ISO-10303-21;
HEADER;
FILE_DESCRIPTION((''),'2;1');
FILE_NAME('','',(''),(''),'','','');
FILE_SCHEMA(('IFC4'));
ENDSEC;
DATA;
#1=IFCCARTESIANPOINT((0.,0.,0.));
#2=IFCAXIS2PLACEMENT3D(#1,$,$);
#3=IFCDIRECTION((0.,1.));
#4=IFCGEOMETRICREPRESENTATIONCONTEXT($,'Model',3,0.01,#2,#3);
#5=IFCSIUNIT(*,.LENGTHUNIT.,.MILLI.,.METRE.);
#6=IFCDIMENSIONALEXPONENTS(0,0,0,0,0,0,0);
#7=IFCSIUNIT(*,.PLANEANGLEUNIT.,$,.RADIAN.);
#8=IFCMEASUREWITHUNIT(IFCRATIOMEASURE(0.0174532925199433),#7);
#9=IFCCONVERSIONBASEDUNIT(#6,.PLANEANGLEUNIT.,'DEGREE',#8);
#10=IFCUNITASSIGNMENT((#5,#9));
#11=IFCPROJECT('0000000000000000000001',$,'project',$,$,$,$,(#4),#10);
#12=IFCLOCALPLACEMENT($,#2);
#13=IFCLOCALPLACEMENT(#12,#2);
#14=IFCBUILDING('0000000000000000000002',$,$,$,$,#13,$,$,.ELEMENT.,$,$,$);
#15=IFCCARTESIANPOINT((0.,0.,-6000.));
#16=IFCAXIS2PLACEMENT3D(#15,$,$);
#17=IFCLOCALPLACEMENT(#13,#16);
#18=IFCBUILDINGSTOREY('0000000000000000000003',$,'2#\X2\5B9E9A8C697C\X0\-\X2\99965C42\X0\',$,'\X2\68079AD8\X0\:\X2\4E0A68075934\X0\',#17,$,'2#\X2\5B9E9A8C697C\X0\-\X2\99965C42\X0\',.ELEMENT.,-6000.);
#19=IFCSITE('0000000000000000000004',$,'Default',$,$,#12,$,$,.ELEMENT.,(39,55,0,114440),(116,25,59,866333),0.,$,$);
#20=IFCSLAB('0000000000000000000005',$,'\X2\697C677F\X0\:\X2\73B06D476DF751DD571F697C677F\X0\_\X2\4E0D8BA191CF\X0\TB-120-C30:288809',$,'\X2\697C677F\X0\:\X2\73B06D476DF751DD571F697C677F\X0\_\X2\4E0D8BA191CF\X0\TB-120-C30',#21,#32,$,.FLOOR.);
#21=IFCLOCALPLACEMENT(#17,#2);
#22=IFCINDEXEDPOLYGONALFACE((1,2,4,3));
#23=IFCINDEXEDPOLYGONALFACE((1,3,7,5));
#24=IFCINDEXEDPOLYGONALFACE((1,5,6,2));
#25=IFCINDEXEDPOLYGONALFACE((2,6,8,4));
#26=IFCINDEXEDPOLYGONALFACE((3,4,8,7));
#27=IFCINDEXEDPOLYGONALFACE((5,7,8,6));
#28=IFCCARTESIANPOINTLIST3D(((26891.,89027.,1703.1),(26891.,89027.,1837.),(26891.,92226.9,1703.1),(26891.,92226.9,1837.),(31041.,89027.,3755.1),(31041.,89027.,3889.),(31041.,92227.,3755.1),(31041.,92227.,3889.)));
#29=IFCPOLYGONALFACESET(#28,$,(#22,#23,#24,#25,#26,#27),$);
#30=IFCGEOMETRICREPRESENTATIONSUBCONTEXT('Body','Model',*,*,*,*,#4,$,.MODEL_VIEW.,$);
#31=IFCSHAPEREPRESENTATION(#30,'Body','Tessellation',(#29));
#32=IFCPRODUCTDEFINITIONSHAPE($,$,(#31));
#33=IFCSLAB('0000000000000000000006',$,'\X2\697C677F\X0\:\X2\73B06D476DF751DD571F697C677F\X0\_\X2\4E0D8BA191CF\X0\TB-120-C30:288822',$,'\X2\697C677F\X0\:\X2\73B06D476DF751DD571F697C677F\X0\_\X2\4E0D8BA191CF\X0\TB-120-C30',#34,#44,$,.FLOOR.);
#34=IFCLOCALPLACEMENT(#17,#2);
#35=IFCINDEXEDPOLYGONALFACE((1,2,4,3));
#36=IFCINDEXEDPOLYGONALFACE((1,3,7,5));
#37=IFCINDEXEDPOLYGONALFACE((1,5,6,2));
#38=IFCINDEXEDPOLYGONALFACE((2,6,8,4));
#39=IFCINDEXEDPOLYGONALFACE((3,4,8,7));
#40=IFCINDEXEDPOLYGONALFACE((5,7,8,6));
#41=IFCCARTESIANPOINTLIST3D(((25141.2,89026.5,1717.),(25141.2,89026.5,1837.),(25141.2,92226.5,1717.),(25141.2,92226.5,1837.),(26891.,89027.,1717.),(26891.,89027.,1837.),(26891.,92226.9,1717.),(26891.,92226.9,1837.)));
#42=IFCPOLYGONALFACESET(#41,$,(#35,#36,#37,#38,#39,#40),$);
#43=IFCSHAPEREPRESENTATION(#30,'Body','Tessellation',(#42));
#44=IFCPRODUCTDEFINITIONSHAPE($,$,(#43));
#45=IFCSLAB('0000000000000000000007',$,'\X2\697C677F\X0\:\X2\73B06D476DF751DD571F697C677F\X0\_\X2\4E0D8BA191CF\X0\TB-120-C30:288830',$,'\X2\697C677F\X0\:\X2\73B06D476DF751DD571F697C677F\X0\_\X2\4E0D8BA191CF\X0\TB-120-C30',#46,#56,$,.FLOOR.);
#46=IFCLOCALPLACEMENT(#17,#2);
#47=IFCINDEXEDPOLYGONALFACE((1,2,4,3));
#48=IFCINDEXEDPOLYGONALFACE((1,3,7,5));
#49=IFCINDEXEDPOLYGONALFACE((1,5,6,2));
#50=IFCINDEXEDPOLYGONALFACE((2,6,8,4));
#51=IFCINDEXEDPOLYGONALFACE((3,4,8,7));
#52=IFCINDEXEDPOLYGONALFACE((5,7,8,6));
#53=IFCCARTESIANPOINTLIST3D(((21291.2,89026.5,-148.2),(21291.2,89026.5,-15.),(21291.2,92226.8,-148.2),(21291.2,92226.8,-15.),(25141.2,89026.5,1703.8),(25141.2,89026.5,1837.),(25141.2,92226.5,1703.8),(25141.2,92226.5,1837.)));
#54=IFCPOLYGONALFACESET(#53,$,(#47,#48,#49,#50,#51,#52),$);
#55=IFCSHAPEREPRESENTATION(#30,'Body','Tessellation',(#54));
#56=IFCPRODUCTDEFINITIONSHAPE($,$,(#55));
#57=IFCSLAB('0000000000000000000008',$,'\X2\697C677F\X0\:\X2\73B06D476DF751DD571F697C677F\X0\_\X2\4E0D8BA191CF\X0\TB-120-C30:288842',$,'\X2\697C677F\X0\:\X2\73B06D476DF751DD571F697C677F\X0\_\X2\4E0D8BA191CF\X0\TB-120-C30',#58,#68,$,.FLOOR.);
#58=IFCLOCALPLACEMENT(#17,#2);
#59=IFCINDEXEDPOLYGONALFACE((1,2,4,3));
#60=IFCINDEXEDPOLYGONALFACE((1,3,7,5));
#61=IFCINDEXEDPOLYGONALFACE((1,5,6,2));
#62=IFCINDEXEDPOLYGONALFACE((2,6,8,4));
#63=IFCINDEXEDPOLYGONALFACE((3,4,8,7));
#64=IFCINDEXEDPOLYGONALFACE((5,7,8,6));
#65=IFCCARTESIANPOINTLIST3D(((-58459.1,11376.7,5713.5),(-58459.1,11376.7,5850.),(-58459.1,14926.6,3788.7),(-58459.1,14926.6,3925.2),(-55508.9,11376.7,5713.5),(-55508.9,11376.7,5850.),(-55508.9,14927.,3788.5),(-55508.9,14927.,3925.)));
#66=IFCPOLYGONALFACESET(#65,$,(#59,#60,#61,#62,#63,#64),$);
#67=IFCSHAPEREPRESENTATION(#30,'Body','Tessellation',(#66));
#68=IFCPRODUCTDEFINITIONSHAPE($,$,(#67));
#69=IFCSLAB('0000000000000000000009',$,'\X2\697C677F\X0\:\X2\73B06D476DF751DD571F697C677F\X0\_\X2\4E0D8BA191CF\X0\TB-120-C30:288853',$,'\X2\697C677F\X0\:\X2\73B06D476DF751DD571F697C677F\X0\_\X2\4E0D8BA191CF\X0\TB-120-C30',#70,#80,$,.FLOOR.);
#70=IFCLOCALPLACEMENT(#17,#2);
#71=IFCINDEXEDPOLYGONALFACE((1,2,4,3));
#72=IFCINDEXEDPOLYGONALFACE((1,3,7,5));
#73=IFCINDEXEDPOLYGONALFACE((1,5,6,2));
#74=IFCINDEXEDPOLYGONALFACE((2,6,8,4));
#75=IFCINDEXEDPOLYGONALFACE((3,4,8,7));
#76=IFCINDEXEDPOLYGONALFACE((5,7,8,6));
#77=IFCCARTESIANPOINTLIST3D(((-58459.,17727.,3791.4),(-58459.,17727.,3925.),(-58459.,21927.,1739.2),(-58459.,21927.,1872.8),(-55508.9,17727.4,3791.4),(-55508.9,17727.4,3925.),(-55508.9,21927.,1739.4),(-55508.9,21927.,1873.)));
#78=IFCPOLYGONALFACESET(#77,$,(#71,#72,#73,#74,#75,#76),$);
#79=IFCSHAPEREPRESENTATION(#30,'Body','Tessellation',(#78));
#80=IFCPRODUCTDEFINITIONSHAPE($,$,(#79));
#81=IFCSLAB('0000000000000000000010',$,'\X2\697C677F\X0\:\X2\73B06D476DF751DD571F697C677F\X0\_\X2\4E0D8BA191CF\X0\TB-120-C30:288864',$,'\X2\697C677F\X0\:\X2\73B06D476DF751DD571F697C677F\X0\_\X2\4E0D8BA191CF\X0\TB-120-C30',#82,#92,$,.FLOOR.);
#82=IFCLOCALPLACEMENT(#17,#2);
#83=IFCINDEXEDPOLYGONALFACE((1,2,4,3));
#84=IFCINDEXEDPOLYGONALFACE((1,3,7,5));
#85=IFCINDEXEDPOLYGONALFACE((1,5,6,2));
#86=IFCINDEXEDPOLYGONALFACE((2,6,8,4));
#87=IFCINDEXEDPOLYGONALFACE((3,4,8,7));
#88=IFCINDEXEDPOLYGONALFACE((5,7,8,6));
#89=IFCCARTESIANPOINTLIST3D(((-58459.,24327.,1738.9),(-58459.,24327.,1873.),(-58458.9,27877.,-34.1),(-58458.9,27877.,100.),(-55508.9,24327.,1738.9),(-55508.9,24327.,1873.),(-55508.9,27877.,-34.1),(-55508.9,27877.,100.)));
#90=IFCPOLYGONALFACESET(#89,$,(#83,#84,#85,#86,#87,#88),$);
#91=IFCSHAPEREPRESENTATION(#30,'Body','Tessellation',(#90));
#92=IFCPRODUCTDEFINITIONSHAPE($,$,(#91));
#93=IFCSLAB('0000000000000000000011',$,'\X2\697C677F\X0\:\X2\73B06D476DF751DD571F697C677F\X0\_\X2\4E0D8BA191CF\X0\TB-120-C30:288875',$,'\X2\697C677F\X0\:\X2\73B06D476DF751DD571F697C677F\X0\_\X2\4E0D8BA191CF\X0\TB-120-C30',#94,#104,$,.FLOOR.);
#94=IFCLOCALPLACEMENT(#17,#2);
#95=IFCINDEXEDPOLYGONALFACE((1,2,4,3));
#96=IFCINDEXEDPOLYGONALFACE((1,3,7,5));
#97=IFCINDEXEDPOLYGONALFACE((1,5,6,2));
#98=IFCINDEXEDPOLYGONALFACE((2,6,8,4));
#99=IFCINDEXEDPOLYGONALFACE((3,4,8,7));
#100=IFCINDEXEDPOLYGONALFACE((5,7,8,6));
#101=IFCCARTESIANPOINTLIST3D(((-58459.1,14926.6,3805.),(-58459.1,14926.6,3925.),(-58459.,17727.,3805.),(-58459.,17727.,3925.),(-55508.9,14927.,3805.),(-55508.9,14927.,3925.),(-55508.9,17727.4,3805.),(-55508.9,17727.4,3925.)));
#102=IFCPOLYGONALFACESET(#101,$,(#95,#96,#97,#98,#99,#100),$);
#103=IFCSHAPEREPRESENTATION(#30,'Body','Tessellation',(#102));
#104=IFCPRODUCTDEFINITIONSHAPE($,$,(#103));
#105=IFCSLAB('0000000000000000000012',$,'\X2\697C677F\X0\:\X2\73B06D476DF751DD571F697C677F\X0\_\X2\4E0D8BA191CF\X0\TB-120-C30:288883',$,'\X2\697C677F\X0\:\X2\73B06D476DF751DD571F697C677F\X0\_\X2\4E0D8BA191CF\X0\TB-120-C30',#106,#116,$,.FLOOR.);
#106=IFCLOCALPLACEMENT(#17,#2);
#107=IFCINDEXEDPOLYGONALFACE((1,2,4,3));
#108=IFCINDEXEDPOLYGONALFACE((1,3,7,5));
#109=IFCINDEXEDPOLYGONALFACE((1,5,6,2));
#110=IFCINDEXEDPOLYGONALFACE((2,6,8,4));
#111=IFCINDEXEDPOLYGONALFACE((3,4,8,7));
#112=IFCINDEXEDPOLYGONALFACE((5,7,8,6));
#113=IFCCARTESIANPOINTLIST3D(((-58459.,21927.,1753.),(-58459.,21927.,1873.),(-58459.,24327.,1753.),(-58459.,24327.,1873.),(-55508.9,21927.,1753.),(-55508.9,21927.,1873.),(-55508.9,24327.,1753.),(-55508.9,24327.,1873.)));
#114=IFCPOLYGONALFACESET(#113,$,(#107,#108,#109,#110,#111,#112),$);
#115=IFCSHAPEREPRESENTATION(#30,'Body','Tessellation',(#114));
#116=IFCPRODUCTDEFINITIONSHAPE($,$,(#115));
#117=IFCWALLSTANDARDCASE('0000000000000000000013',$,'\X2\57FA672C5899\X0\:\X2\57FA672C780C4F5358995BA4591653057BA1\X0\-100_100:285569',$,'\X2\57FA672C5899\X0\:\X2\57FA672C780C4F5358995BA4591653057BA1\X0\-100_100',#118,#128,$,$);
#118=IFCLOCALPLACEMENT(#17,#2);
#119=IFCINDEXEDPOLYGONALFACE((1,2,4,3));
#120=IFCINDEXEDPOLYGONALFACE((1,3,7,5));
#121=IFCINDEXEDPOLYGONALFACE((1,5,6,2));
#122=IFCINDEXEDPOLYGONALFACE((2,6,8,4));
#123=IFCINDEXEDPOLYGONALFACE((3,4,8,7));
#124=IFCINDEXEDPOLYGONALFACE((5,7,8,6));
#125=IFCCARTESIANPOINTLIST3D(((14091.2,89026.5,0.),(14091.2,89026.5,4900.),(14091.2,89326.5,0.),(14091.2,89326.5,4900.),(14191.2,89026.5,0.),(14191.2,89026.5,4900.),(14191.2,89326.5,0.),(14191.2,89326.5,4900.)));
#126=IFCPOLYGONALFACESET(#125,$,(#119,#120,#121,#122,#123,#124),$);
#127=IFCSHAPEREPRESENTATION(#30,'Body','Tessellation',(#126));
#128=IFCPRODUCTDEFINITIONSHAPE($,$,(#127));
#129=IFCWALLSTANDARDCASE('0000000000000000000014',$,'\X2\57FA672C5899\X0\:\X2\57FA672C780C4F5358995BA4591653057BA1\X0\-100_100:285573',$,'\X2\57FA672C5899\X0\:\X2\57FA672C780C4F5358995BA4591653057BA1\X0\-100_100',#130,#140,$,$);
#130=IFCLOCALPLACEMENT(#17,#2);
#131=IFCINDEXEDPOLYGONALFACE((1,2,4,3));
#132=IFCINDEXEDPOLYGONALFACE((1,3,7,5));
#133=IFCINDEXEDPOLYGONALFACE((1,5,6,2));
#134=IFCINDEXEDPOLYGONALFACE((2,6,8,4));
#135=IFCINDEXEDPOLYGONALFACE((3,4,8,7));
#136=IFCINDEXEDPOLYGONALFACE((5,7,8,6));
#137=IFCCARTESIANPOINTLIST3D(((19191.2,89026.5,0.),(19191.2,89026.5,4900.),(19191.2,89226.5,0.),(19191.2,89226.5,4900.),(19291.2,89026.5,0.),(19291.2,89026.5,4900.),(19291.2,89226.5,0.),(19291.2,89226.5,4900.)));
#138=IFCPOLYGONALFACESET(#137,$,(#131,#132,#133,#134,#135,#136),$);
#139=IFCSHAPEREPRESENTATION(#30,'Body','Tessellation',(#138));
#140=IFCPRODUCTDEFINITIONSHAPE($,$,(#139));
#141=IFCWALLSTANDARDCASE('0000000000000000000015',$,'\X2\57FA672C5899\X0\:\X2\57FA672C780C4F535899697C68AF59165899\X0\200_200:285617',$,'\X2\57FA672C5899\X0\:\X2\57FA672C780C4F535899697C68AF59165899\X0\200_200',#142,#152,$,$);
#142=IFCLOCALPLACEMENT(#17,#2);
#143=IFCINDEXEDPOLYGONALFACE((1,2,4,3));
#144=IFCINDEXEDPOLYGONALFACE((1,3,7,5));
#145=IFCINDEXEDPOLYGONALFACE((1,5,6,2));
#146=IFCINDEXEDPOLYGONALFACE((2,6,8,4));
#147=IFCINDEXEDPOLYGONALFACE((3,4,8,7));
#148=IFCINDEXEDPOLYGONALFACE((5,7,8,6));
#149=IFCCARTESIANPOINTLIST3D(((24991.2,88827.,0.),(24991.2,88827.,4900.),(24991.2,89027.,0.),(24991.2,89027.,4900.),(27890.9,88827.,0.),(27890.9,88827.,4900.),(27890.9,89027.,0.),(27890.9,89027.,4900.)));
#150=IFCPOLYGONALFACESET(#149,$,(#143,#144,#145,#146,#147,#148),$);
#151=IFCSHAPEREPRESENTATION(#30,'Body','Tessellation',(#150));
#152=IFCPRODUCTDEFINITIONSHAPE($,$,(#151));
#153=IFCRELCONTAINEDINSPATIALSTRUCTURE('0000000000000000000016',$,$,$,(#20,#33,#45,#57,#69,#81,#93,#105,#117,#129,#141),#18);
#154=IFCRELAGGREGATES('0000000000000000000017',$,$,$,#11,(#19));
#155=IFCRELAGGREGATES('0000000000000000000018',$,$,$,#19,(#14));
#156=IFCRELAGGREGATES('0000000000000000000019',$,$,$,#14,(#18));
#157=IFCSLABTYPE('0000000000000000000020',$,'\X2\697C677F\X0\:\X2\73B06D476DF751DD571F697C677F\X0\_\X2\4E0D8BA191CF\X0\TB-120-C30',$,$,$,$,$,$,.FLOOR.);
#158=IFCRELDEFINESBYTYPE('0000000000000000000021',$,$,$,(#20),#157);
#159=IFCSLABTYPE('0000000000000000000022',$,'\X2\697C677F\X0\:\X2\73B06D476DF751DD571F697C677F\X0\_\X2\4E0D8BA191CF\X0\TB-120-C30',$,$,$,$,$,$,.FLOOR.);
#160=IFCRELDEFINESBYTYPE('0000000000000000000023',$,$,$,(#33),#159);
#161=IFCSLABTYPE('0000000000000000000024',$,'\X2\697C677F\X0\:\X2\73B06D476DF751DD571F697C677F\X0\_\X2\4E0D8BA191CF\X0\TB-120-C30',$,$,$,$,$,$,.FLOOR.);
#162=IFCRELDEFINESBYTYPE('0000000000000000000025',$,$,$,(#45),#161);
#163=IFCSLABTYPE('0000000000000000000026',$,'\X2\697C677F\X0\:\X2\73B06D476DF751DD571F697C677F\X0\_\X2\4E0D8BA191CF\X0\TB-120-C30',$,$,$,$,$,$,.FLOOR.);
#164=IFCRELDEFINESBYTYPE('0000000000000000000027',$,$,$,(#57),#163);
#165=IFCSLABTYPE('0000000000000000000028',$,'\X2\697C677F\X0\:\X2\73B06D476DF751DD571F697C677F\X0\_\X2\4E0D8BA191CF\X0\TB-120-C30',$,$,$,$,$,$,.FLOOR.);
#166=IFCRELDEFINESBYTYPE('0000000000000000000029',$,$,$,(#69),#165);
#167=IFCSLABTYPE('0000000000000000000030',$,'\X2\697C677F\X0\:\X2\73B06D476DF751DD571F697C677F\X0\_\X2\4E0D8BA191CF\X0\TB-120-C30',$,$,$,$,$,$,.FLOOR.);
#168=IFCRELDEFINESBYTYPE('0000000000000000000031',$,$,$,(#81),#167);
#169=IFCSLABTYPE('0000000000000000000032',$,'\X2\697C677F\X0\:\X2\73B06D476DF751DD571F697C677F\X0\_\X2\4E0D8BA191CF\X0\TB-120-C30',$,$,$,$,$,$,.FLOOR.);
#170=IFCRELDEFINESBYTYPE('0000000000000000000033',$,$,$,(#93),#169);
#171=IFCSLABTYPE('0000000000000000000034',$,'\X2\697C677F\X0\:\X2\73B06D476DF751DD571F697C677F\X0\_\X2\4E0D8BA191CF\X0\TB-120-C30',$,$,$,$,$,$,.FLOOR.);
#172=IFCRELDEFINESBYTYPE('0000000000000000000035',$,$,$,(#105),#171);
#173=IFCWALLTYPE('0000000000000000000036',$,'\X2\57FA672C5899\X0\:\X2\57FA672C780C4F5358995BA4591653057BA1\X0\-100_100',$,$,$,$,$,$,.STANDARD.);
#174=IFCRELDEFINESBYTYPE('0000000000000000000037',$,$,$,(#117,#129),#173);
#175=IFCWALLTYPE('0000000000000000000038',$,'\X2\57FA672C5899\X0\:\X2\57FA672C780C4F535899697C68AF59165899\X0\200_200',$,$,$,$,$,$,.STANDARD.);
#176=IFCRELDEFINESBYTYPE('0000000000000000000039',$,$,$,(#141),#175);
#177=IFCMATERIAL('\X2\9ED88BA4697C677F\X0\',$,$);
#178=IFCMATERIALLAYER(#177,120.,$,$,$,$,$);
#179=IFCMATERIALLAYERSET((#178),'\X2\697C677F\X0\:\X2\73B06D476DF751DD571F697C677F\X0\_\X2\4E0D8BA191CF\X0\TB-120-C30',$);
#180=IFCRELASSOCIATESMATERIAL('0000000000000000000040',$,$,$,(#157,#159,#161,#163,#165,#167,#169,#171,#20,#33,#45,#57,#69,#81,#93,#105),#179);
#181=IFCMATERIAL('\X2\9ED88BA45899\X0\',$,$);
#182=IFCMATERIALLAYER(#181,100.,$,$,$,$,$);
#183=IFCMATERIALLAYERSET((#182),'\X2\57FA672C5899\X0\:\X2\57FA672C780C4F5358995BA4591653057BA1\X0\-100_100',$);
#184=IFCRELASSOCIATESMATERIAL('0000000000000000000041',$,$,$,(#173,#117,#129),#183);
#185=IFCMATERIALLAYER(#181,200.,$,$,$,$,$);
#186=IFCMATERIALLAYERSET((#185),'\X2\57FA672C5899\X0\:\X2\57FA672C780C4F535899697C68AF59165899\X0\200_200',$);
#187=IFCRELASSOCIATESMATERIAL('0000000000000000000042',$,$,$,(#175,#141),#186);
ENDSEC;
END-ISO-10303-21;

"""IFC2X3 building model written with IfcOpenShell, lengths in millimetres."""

from ifc_helpers import new_model, entity, si_unit, converted_unit, direction, frame, frame_2d, origin, place, context, subcontext, project, spatial, polyline, rectangle, outline, extrude, clip, halfspace, material, layer, layer_set, layer_usage, type_object, element, save


model = new_model("IFC2X3")

# Units and contexts
model_context = context("Model", 3, precision=0.01, world=origin(), true_north=direction((0.0, 1.0)))
body_context = subcontext(model_context, "Body", "Model", "MODEL_VIEW")
ifc_project = project(units=[si_unit("LENGTHUNIT", "METRE", prefix="MILLI"), converted_unit("PLANEANGLEUNIT", "DEGREE", entity("IfcRatioMeasure", 0.0174532925199433), si_unit("PLANEANGLEUNIT", "RADIAN"), dimensions=[0, 0, 0, 0, 0, 0, 0])], contexts=[model_context])

# Site, building, storey
site_placement = place(None, origin())
site = spatial("IfcSite", under=ifc_project, at=site_placement, Name="Default", CompositionType="ELEMENT", RefLatitude=(39, 55, 0, 114440), RefLongitude=(116, 25, 59, 866333), RefElevation=0.0)
building_placement = place(site_placement, origin())
building = spatial("IfcBuilding", under=site, at=building_placement, CompositionType="ELEMENT")
storey_placement = place(building_placement, frame((0.0, 0.0, -6000.0)))
storey = spatial("IfcBuildingStorey", under=building, at=storey_placement, Name="2#实验楼-首层", ObjectType="标高:上标头", LongName="2#实验楼-首层", CompositionType="ELEMENT", Elevation=-6000.0)

# Slabs
ifc_material_1 = material(Name="默认楼板")
ifc_layer_1 = layer(ifc_material_1, 120.0)
ifc_layer_set_1 = layer_set([ifc_layer_1], Name="楼板:现浇混凝土楼板_不计量TB-120-C30")
ifc_layer_usage_1 = layer_usage(ifc_layer_set_1, "AXIS3", "POSITIVE", 0.0)
slab_type_1 = type_object("IfcSlabType", Name="楼板:现浇混凝土楼板_不计量TB-120-C30", PredefinedType="FLOOR", material=ifc_layer_set_1)
slab_1_placement = place(storey_placement, origin())
element("IfcSlab", 1, at=slab_1_placement, inside=storey, type_object=slab_type_1, material=ifc_layer_usage_1, Name="楼板:现浇混凝土楼板_不计量TB-120-C30:288809", ObjectType="楼板:现浇混凝土楼板_不计量TB-120-C30", PredefinedType="FLOOR", context=body_context, shape_type="Clipping", body=[
    clip(clip(extrude(outline(polyline([(-1600.0, -2314.8), (1599.9, -2314.8), (1600.0, 2314.8), (-1600.0, 2314.8), (-1600.0, -2314.8)])), frame((28966.0, 90627.0, 2863.0), z_axis=(0.443235, 0.0, -0.896405), x_axis=(0.0, 1.0, 0.0)), (0.0, -0.443235, 0.896405), 149.3), halfspace(frame((31041.0, 89027.0, 3755.1), z_axis=(0.443235, 0.0, -0.896405), x_axis=(0.896405, 0.0, 0.443235)), False)), halfspace(frame((31041.0, 89027.0, 3889.0), z_axis=(-0.443235, 0.0, 0.896405), x_axis=(-0.896405, 0.0, -0.443235)), False)),
])
ifc_layer_usage_2 = layer_usage(ifc_layer_set_1, "AXIS3", "POSITIVE", 0.0)
slab_type_2 = type_object("IfcSlabType", Name="楼板:现浇混凝土楼板_不计量TB-120-C30", PredefinedType="FLOOR", material=ifc_layer_set_1)
slab_2_placement = place(storey_placement, origin())
element("IfcSlab", 2, at=slab_2_placement, inside=storey, type_object=slab_type_2, material=ifc_layer_usage_2, Name="楼板:现浇混凝土楼板_不计量TB-120-C30:288822", ObjectType="楼板:现浇混凝土楼板_不计量TB-120-C30", PredefinedType="FLOOR", context=body_context, shape_type="SweptSolid", body=[
    extrude(outline(polyline([(-1600.1, -874.9), (1599.7, -874.9), (1600.2, 874.9), (-1599.8, 874.9), (-1600.1, -874.9)])), frame((26016.1, 90626.7, 1837.0), z_axis=(0.0, 0.0, -1.0), x_axis=(0.0, -1.0, 0.0)), (0.0, 0.0, 1.0), 120.0),
])
ifc_layer_usage_3 = layer_usage(ifc_layer_set_1, "AXIS3", "POSITIVE", 0.0)
slab_type_3 = type_object("IfcSlabType", Name="楼板:现浇混凝土楼板_不计量TB-120-C30", PredefinedType="FLOOR", material=ifc_layer_set_1)
slab_3_placement = place(storey_placement, origin())
element("IfcSlab", 3, at=slab_3_placement, inside=storey, type_object=slab_type_3, material=ifc_layer_usage_3, Name="楼板:现浇混凝土楼板_不计量TB-120-C30:288830", ObjectType="楼板:现浇混凝土楼板_不计量TB-120-C30", PredefinedType="FLOOR", context=body_context, shape_type="Clipping", body=[
    clip(clip(extrude(outline(polyline([(-2136.2, -1600.1), (2136.0, -1600.1), (2136.2, 1599.9), (-2136.0, 1600.2), (-2136.2, -1600.1)])), frame((23216.2, 90626.6, 911.0), z_axis=(0.433492, -0.000001, -0.901158), x_axis=(0.901158, -0.000063, 0.433492)), (-0.433492, 0.000027, 0.901158), 147.8), halfspace(frame((21291.2, 92226.8, -148.2), z_axis=(0.433492, -0.000001, -0.901158), x_axis=(0.901158, -0.000001, 0.433492)), False)), halfspace(frame((21291.2, 92226.8, -15.0), z_axis=(-0.433492, 0.000001, 0.901158), x_axis=(-0.901158, 0.000001, -0.433492)), False)),
])
ifc_layer_usage_4 = layer_usage(ifc_layer_set_1, "AXIS3", "POSITIVE", 0.0)
slab_type_4 = type_object("IfcSlabType", Name="楼板:现浇混凝土楼板_不计量TB-120-C30", PredefinedType="FLOOR", material=ifc_layer_set_1)
slab_4_placement = place(storey_placement, origin())
element("IfcSlab", 4, at=slab_4_placement, inside=storey, type_object=slab_type_4, material=ifc_layer_usage_4, Name="楼板:现浇混凝土楼板_不计量TB-120-C30:288842", ObjectType="楼板:现浇混凝土楼板_不计量TB-120-C30", PredefinedType="FLOOR", context=body_context, shape_type="Clipping", body=[
    clip(clip(extrude(outline(polyline([(-2019.4, -1475.1), (2019.2, -1475.1), (2019.2, 1475.1), (-2019.0, 1475.1), (-2019.4, -1475.1)])), frame((-56984.0, 13151.7, 4887.6), z_axis=(-0.000001, -0.476646, -0.879095), x_axis=(-0.000001, -0.879095, 0.476646)), (-0.476646, 0.0, 0.879095), 155.3), halfspace(frame((-55508.9, 11376.7, 5713.5), z_axis=(-0.000001, -0.476646, -0.879095), x_axis=(-0.000001, -0.879095, 0.476646)), False)), halfspace(frame((-55508.9, 11376.7, 5850.0), z_axis=(0.000001, 0.476646, 0.879095), x_axis=(0.000001, 0.879095, -0.476646)), False)),
])
ifc_layer_usage_5 = layer_usage(ifc_layer_set_1, "AXIS3", "POSITIVE", 0.0)
slab_type_5 = type_object("IfcSlabType", Name="楼板:现浇混凝土楼板_不计量TB-120-C30", PredefinedType="FLOOR", material=ifc_layer_set_1)
slab_5_placement = place(storey_placement, origin())
element("IfcSlab", 5, at=slab_5_placement, inside=storey, type_object=slab_type_5, material=ifc_layer_usage_5, Name="楼板:现浇混凝土楼板_不计量TB-120-C30:288853", ObjectType="楼板:现浇混凝土楼板_不计量TB-120-C30", PredefinedType="FLOOR", context=body_context, shape_type="Clipping", body=[
    clip(clip(extrude(outline(polyline([(-2337.1, -1475.1), (2337.0, -1475.1), (2337.4, 1475.1), (-2337.2, 1475.0), (-2337.1, -1475.1)])), frame((-56984.0, 19827.1, 2899.0), z_axis=(0.00006, -0.439011, -0.898482), x_axis=(-0.000001, -0.898482, 0.439011)), (-0.439011, 0.000055, 0.898482), 148.6), halfspace(frame((-55508.9, 17727.4, 3791.4), z_axis=(0.00006, -0.439011, -0.898482), x_axis=(0.000123, -0.898482, 0.439011)), False)), halfspace(frame((-55508.9, 17727.4, 3925.0), z_axis=(-0.00006, 0.439011, 0.898482), x_axis=(-0.000123, 0.898482, -0.439011)), False)),
])
ifc_layer_usage_6 = layer_usage(ifc_layer_set_1, "AXIS3", "POSITIVE", 0.0)
slab_type_6 = type_object("IfcSlabType", Name="楼板:现浇混凝土楼板_不计量TB-120-C30", PredefinedType="FLOOR", material=ifc_layer_set_1)
slab_6_placement = place(storey_placement, origin())
element("IfcSlab", 6, at=slab_6_placement, inside=storey, type_object=slab_type_6, material=ifc_layer_usage_6, Name="楼板:现浇混凝土楼板_不计量TB-120-C30:288864", ObjectType="楼板:现浇混凝土楼板_不计量TB-120-C30", PredefinedType="FLOOR", context=body_context, shape_type="Clipping", body=[
    clip(clip(extrude(outline(polyline([(-1475.0, -1984.1), (1475.1, -1984.1), (1475.0, 1984.1), (-1475.0, 1984.1), (-1475.0, -1984.1)])), frame((-56983.9, 26102.0, 986.5), z_axis=(0.0, -0.44681, -0.894629), x_axis=(-1.0, 0.0, 0.0)), (0.0, 0.44681, 0.894629), 149.9), halfspace(frame((-55508.9, 24327.0, 1738.9), z_axis=(0.0, -0.44681, -0.894629), x_axis=(0.0, -0.894629, 0.44681)), False)), halfspace(frame((-55508.9, 24327.0, 1873.0), z_axis=(0.0, 0.44681, 0.894629), x_axis=(0.0, 0.894629, -0.44681)), False)),
])
ifc_layer_usage_7 = layer_usage(ifc_layer_set_1, "AXIS3", "POSITIVE", 0.0)
slab_type_7 = type_object("IfcSlabType", Name="楼板:现浇混凝土楼板_不计量TB-120-C30", PredefinedType="FLOOR", material=ifc_layer_set_1)
slab_7_placement = place(storey_placement, origin())
element("IfcSlab", 7, at=slab_7_placement, inside=storey, type_object=slab_type_7, material=ifc_layer_usage_7, Name="楼板:现浇混凝土楼板_不计量TB-120-C30:288875", ObjectType="楼板:现浇混凝土楼板_不计量TB-120-C30", PredefinedType="FLOOR", context=body_context, shape_type="SweptSolid", body=[
    extrude(outline(polyline([(-1400.4, -1475.1), (1400.0, -1475.1), (1400.4, 1475.1), (-1400.0, 1475.1), (-1400.4, -1475.1)])), frame((-56984.0, 16327.0, 3925.0), z_axis=(0.0, 0.0, -1.0), x_axis=(-0.000002, -1.0, 0.0)), (0.0, 0.0, 1.0), 120.0),
])
ifc_layer_usage_8 = layer_usage(ifc_layer_set_1, "AXIS3", "POSITIVE", 0.0)
slab_type_8 = type_object("IfcSlabType", Name="楼板:现浇混凝土楼板_不计量TB-120-C30", PredefinedType="FLOOR", material=ifc_layer_set_1)
slab_8_placement = place(storey_placement, origin())
element("IfcSlab", 8, at=slab_8_placement, inside=storey, type_object=slab_type_8, material=ifc_layer_usage_8, Name="楼板:现浇混凝土楼板_不计量TB-120-C30:288883", ObjectType="楼板:现浇混凝土楼板_不计量TB-120-C30", PredefinedType="FLOOR", context=body_context, shape_type="SweptSolid", body=[
    extrude(outline(polyline([(-1475.0, -1200.0), (1475.1, -1200.0), (1475.0, 1200.0), (-1475.0, 1200.0), (-1475.0, -1200.0)])), frame((-56983.9, 23127.0, 1873.0), z_axis=(0.0, 0.0, -1.0), x_axis=(-1.0, 0.0, 0.0)), (0.0, 0.0, 1.0), 120.0),
])

# Walls
ifc_material_2 = material(Name="默认墙")
ifc_layer_2 = layer(ifc_material_2, 100.0)
ifc_layer_set_2 = layer_set([ifc_layer_2], Name="基本墙:基本砌体墙室外包管-100_100")
ifc_layer_usage_9 = layer_usage(ifc_layer_set_2, "AXIS2", "NEGATIVE", 50.0)
wall_type_1 = type_object("IfcWallType", Name="基本墙:基本砌体墙室外包管-100_100", PredefinedType="STANDARD", material=ifc_layer_set_2)
wall_1_placement = place(storey_placement, frame((14141.2, 89026.5, 0.0), z_axis=(0.0, 0.0, 1.0), x_axis=(0.0, 1.0, 0.0)))
element("IfcWallStandardCase", 9, at=wall_1_placement, inside=storey, type_object=wall_type_1, material=ifc_layer_usage_9, Name="基本墙:基本砌体墙室外包管-100_100:285569", ObjectType="基本墙:基本砌体墙室外包管-100_100", context=body_context, shape_type="SweptSolid", body=[
    extrude(rectangle(XDim=300.0, YDim=100.0, at=frame_2d((150.0, 0.0), x_axis=(-1.0, 0.0))), origin(), (0.0, 0.0, 1.0), 4900.0),
])
ifc_layer_usage_10 = layer_usage(ifc_layer_set_2, "AXIS2", "NEGATIVE", 50.0)
wall_2_placement = place(storey_placement, frame((19241.2, 89026.5, 0.0), z_axis=(0.0, 0.0, 1.0), x_axis=(0.0, 1.0, 0.0)))
element("IfcWallStandardCase", 10, at=wall_2_placement, inside=storey, type_object=wall_type_1, material=ifc_layer_usage_10, Name="基本墙:基本砌体墙室外包管-100_100:285573", ObjectType="基本墙:基本砌体墙室外包管-100_100", context=body_context, shape_type="SweptSolid", body=[
    extrude(rectangle(XDim=200.0, YDim=100.0, at=frame_2d((100.0, 0.0), x_axis=(-1.0, 0.0))), origin(), (0.0, 0.0, 1.0), 4900.0),
])
ifc_layer_3 = layer(ifc_material_2, 200.0)
ifc_layer_set_3 = layer_set([ifc_layer_3], Name="基本墙:基本砌体墙楼梯外墙200_200")
ifc_layer_usage_11 = layer_usage(ifc_layer_set_3, "AXIS2", "NEGATIVE", 100.0)
wall_type_2 = type_object("IfcWallType", Name="基本墙:基本砌体墙楼梯外墙200_200", PredefinedType="STANDARD", material=ifc_layer_set_3)
wall_3_placement = place(storey_placement, frame((24991.2, 88927.0, 0.0)))
element("IfcWallStandardCase", 11, at=wall_3_placement, inside=storey, type_object=wall_type_2, material=ifc_layer_usage_11, Name="基本墙:基本砌体墙楼梯外墙200_200:285617", ObjectType="基本墙:基本砌体墙楼梯外墙200_200", context=body_context, shape_type="SweptSolid", body=[
    extrude(rectangle(XDim=2899.7, YDim=200.0, at=frame_2d((1449.9, 0.0), x_axis=(-1.0, 0.0))), origin(), (0.0, 0.0, 1.0), 4900.0),
])

save(model, "model.ifc")
